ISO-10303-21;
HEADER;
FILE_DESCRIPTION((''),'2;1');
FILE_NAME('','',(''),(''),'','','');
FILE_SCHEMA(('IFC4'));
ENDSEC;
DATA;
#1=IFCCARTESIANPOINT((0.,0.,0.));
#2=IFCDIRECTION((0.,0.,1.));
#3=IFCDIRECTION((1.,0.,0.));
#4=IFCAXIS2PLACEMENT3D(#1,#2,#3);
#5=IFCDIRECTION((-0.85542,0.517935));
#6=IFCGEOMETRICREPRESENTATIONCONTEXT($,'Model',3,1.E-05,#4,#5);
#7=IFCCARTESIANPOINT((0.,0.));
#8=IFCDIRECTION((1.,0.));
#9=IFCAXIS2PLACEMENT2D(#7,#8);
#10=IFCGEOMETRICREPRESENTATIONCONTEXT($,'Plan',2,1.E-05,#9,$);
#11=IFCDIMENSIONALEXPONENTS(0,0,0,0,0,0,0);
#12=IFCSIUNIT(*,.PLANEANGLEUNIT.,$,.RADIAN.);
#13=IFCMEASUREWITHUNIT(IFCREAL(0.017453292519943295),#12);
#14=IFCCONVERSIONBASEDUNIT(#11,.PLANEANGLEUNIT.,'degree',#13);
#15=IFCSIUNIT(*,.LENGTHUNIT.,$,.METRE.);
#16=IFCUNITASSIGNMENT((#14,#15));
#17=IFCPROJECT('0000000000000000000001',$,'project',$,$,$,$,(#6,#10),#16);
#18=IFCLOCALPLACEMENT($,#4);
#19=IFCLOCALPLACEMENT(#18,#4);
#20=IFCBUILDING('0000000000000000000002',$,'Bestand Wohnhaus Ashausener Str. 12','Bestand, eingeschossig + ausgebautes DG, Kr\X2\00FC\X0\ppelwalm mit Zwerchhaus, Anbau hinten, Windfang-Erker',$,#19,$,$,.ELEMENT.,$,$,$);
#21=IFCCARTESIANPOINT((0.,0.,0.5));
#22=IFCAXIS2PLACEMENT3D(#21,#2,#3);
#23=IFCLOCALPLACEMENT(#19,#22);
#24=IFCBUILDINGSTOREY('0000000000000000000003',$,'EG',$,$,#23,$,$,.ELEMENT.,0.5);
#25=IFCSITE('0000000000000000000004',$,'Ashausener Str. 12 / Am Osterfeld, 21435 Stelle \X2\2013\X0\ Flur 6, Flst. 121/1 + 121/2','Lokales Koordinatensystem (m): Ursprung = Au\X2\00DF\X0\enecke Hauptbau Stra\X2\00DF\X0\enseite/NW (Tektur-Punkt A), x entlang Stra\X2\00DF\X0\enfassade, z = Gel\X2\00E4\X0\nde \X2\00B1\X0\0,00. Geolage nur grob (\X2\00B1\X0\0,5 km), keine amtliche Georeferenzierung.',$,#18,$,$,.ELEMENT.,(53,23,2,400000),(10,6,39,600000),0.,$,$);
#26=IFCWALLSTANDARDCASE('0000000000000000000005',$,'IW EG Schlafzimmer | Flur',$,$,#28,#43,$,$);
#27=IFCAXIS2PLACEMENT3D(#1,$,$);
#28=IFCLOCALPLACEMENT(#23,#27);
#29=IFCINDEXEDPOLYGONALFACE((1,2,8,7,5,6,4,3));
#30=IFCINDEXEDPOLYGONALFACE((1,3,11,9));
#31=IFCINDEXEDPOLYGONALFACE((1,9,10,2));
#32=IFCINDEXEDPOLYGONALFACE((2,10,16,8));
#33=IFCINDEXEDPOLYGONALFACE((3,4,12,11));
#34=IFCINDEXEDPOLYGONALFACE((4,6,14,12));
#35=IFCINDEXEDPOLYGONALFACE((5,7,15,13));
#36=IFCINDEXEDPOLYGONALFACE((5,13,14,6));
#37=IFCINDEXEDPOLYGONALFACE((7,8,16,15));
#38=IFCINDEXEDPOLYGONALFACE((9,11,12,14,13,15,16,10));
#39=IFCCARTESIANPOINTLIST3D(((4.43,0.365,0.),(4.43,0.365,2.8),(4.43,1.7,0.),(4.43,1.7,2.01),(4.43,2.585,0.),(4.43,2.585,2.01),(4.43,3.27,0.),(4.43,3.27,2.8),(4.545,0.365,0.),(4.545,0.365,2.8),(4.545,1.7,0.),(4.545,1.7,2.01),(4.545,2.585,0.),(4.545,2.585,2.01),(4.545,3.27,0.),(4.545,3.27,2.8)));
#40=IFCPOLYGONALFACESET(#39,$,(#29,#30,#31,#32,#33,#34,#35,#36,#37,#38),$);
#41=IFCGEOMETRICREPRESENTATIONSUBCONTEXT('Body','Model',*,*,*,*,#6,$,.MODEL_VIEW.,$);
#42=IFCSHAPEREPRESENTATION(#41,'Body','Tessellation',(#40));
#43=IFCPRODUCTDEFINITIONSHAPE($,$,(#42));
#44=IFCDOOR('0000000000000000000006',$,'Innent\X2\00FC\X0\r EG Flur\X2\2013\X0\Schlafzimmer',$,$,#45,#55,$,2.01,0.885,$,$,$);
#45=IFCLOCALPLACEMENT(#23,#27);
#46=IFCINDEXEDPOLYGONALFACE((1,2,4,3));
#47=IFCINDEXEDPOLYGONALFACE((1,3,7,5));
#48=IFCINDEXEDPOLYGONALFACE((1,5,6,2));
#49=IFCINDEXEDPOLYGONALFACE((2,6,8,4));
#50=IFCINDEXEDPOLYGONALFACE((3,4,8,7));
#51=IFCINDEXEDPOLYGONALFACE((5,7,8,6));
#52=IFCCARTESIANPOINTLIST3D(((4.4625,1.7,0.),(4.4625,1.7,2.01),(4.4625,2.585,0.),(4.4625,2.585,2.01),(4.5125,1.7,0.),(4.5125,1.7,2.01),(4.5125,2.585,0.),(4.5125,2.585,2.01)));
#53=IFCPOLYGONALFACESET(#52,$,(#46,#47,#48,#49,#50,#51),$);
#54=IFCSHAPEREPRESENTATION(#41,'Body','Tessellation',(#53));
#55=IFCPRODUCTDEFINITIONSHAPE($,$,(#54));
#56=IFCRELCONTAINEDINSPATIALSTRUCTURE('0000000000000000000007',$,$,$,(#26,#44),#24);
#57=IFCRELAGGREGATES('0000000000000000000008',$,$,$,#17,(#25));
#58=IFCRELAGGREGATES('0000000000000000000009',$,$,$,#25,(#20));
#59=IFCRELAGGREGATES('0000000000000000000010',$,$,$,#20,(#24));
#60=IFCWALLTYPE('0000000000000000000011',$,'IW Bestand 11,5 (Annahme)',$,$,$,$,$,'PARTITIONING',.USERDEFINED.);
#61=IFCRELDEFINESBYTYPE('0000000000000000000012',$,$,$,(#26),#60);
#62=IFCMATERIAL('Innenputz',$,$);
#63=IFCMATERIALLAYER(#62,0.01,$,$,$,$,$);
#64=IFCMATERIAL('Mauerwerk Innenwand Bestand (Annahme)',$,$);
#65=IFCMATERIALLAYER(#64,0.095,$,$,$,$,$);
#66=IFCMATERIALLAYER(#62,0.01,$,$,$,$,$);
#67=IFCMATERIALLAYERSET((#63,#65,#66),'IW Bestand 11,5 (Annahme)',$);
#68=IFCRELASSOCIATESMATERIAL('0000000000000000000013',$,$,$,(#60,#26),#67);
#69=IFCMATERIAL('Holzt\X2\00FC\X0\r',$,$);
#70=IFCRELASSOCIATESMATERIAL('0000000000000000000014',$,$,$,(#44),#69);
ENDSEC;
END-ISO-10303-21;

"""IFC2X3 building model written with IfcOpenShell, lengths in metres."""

from ifc_helpers import new_model, entity, si_unit, converted_unit, direction, frame, origin_with_axes, origin_2d_with_axis, place, context, subcontext, project, spatial, polyline, outline, extrude, material, layer, layer_set, layer_usage, type_object, element, fill, save


model = new_model("IFC2X3")

# Units and contexts
model_context = context("Model", 3, precision=1e-05, world=origin_with_axes(), true_north=direction((-0.85542, 0.517935)))
plan_context = context("Plan", 2, precision=1e-05, world=origin_2d_with_axis())
body_context = subcontext(model_context, "Body", "Model", "MODEL_VIEW")
ifc_project = project(units=[converted_unit("PLANEANGLEUNIT", "degree", entity("IfcReal", 0.017453292519943295), si_unit("PLANEANGLEUNIT", "RADIAN"), dimensions=[0, 0, 0, 0, 0, 0, 0]), si_unit("LENGTHUNIT", "METRE")], contexts=[model_context, plan_context])

# Site, building, storey
site_placement = place(None, origin_with_axes())
site = spatial("IfcSite", under=ifc_project, at=site_placement, Name="Ashausener Str. 12 / Am Osterfeld, 21435 Stelle – Flur 6, Flst. 121/1 + 121/2", Description="Lokales Koordinatensystem (m): Ursprung = Außenecke Hauptbau Straßenseite/NW (Tektur-Punkt A), x entlang Straßenfassade, z = Gelände ±0,00. Geolage nur grob (±0,5 km), keine amtliche Georeferenzierung.", CompositionType="ELEMENT", RefLatitude=(53, 23, 2, 400000), RefLongitude=(10, 6, 39, 600000), RefElevation=0.0)
building_placement = place(site_placement, origin_with_axes())
building = spatial("IfcBuilding", under=site, at=building_placement, Name="Bestand Wohnhaus Ashausener Str. 12", Description="Bestand, eingeschossig + ausgebautes DG, Krüppelwalm mit Zwerchhaus, Anbau hinten, Windfang-Erker", CompositionType="ELEMENT")
storey_placement = place(building_placement, frame((0.0, 0.0, 0.5), z_axis=(0.0, 0.0, 1.0), x_axis=(1.0, 0.0, 0.0)))
storey = spatial("IfcBuildingStorey", under=building, at=storey_placement, Name="EG", CompositionType="ELEMENT", Elevation=0.5)

# Shared definitions
ifc_material_1 = material(Name="Holztür")

# Shared definitions
ifc_material_2 = material(Name="Innenputz")
ifc_layer_1 = layer(ifc_material_2, 0.01)
ifc_material_3 = material(Name="Mauerwerk Innenwand Bestand (Annahme)")
ifc_layer_2 = layer(ifc_material_3, 0.095)
ifc_layer_3 = layer(ifc_material_2, 0.01)
ifc_layer_set_1 = layer_set([ifc_layer_1, ifc_layer_2, ifc_layer_3], Name="IW Bestand 11,5 (Annahme)")
wall_type_1 = type_object("IfcWallType", Name="IW Bestand 11,5 (Annahme)", ElementType="PARTITIONING", PredefinedType="USERDEFINED", material=ifc_layer_set_1)

# Wall, opening, door
ifc_layer_usage_1 = layer_usage(ifc_layer_set_1, "AXIS2", "POSITIVE", 0.0)
wall_1_placement = place(storey_placement, frame((4.43, 3.27, 0.0), z_axis=(0.0, 0.0, 1.0), x_axis=(0.0, -1.0, 0.0)))
wall_1 = element("IfcWallStandardCase", 1, at=wall_1_placement, inside=storey, type_object=wall_type_1, material=ifc_layer_usage_1, Name="IW EG Schlafzimmer | Flur", context=body_context, shape_type="SweptSolid", body=[
    extrude(outline(polyline([(0.0, 0.0), (0.0, 0.115), (2.905, 0.115), (2.905, 0.0), (0.0, 0.0)])), origin_with_axes(), (0.0, 0.0, 1.0), 2.8),
])
opening_1_placement = place(wall_1_placement, frame((0.685, -0.1, 0.0), z_axis=(0.0, 0.0, 1.0), x_axis=(1.0, 0.0, 0.0)))
opening_1 = element("IfcOpeningElement", 2, at=opening_1_placement, cuts=wall_1, context=body_context, shape_type="SweptSolid", body=[
    extrude(outline(polyline([(0.0, 0.0), (0.0, 0.315), (0.885, 0.315), (0.885, 0.0), (0.0, 0.0)])), origin_with_axes(), (0.0, 0.0, 1.0), 2.01),
])
door_1_placement = place(storey_placement, frame((4.4625, 2.585, 0.0), z_axis=(0.0, 0.0, 1.0), x_axis=(0.0, -1.0, 0.0)))
door_1 = element("IfcDoor", 3, at=door_1_placement, inside=storey, material=ifc_material_1, Name="Innentür EG Flur–Schlafzimmer", OverallHeight=2.01, OverallWidth=0.885, context=body_context, shape_type="SweptSolid", body=[
    extrude(outline(polyline([(0.0, 0.0), (0.0, 0.05), (0.885, 0.05), (0.885, 0.0), (0.0, 0.0)])), origin_with_axes(), (0.0, 0.0, 1.0), 2.01),
])
fill(opening_1, door_1)

save(model, "model.ifc")
